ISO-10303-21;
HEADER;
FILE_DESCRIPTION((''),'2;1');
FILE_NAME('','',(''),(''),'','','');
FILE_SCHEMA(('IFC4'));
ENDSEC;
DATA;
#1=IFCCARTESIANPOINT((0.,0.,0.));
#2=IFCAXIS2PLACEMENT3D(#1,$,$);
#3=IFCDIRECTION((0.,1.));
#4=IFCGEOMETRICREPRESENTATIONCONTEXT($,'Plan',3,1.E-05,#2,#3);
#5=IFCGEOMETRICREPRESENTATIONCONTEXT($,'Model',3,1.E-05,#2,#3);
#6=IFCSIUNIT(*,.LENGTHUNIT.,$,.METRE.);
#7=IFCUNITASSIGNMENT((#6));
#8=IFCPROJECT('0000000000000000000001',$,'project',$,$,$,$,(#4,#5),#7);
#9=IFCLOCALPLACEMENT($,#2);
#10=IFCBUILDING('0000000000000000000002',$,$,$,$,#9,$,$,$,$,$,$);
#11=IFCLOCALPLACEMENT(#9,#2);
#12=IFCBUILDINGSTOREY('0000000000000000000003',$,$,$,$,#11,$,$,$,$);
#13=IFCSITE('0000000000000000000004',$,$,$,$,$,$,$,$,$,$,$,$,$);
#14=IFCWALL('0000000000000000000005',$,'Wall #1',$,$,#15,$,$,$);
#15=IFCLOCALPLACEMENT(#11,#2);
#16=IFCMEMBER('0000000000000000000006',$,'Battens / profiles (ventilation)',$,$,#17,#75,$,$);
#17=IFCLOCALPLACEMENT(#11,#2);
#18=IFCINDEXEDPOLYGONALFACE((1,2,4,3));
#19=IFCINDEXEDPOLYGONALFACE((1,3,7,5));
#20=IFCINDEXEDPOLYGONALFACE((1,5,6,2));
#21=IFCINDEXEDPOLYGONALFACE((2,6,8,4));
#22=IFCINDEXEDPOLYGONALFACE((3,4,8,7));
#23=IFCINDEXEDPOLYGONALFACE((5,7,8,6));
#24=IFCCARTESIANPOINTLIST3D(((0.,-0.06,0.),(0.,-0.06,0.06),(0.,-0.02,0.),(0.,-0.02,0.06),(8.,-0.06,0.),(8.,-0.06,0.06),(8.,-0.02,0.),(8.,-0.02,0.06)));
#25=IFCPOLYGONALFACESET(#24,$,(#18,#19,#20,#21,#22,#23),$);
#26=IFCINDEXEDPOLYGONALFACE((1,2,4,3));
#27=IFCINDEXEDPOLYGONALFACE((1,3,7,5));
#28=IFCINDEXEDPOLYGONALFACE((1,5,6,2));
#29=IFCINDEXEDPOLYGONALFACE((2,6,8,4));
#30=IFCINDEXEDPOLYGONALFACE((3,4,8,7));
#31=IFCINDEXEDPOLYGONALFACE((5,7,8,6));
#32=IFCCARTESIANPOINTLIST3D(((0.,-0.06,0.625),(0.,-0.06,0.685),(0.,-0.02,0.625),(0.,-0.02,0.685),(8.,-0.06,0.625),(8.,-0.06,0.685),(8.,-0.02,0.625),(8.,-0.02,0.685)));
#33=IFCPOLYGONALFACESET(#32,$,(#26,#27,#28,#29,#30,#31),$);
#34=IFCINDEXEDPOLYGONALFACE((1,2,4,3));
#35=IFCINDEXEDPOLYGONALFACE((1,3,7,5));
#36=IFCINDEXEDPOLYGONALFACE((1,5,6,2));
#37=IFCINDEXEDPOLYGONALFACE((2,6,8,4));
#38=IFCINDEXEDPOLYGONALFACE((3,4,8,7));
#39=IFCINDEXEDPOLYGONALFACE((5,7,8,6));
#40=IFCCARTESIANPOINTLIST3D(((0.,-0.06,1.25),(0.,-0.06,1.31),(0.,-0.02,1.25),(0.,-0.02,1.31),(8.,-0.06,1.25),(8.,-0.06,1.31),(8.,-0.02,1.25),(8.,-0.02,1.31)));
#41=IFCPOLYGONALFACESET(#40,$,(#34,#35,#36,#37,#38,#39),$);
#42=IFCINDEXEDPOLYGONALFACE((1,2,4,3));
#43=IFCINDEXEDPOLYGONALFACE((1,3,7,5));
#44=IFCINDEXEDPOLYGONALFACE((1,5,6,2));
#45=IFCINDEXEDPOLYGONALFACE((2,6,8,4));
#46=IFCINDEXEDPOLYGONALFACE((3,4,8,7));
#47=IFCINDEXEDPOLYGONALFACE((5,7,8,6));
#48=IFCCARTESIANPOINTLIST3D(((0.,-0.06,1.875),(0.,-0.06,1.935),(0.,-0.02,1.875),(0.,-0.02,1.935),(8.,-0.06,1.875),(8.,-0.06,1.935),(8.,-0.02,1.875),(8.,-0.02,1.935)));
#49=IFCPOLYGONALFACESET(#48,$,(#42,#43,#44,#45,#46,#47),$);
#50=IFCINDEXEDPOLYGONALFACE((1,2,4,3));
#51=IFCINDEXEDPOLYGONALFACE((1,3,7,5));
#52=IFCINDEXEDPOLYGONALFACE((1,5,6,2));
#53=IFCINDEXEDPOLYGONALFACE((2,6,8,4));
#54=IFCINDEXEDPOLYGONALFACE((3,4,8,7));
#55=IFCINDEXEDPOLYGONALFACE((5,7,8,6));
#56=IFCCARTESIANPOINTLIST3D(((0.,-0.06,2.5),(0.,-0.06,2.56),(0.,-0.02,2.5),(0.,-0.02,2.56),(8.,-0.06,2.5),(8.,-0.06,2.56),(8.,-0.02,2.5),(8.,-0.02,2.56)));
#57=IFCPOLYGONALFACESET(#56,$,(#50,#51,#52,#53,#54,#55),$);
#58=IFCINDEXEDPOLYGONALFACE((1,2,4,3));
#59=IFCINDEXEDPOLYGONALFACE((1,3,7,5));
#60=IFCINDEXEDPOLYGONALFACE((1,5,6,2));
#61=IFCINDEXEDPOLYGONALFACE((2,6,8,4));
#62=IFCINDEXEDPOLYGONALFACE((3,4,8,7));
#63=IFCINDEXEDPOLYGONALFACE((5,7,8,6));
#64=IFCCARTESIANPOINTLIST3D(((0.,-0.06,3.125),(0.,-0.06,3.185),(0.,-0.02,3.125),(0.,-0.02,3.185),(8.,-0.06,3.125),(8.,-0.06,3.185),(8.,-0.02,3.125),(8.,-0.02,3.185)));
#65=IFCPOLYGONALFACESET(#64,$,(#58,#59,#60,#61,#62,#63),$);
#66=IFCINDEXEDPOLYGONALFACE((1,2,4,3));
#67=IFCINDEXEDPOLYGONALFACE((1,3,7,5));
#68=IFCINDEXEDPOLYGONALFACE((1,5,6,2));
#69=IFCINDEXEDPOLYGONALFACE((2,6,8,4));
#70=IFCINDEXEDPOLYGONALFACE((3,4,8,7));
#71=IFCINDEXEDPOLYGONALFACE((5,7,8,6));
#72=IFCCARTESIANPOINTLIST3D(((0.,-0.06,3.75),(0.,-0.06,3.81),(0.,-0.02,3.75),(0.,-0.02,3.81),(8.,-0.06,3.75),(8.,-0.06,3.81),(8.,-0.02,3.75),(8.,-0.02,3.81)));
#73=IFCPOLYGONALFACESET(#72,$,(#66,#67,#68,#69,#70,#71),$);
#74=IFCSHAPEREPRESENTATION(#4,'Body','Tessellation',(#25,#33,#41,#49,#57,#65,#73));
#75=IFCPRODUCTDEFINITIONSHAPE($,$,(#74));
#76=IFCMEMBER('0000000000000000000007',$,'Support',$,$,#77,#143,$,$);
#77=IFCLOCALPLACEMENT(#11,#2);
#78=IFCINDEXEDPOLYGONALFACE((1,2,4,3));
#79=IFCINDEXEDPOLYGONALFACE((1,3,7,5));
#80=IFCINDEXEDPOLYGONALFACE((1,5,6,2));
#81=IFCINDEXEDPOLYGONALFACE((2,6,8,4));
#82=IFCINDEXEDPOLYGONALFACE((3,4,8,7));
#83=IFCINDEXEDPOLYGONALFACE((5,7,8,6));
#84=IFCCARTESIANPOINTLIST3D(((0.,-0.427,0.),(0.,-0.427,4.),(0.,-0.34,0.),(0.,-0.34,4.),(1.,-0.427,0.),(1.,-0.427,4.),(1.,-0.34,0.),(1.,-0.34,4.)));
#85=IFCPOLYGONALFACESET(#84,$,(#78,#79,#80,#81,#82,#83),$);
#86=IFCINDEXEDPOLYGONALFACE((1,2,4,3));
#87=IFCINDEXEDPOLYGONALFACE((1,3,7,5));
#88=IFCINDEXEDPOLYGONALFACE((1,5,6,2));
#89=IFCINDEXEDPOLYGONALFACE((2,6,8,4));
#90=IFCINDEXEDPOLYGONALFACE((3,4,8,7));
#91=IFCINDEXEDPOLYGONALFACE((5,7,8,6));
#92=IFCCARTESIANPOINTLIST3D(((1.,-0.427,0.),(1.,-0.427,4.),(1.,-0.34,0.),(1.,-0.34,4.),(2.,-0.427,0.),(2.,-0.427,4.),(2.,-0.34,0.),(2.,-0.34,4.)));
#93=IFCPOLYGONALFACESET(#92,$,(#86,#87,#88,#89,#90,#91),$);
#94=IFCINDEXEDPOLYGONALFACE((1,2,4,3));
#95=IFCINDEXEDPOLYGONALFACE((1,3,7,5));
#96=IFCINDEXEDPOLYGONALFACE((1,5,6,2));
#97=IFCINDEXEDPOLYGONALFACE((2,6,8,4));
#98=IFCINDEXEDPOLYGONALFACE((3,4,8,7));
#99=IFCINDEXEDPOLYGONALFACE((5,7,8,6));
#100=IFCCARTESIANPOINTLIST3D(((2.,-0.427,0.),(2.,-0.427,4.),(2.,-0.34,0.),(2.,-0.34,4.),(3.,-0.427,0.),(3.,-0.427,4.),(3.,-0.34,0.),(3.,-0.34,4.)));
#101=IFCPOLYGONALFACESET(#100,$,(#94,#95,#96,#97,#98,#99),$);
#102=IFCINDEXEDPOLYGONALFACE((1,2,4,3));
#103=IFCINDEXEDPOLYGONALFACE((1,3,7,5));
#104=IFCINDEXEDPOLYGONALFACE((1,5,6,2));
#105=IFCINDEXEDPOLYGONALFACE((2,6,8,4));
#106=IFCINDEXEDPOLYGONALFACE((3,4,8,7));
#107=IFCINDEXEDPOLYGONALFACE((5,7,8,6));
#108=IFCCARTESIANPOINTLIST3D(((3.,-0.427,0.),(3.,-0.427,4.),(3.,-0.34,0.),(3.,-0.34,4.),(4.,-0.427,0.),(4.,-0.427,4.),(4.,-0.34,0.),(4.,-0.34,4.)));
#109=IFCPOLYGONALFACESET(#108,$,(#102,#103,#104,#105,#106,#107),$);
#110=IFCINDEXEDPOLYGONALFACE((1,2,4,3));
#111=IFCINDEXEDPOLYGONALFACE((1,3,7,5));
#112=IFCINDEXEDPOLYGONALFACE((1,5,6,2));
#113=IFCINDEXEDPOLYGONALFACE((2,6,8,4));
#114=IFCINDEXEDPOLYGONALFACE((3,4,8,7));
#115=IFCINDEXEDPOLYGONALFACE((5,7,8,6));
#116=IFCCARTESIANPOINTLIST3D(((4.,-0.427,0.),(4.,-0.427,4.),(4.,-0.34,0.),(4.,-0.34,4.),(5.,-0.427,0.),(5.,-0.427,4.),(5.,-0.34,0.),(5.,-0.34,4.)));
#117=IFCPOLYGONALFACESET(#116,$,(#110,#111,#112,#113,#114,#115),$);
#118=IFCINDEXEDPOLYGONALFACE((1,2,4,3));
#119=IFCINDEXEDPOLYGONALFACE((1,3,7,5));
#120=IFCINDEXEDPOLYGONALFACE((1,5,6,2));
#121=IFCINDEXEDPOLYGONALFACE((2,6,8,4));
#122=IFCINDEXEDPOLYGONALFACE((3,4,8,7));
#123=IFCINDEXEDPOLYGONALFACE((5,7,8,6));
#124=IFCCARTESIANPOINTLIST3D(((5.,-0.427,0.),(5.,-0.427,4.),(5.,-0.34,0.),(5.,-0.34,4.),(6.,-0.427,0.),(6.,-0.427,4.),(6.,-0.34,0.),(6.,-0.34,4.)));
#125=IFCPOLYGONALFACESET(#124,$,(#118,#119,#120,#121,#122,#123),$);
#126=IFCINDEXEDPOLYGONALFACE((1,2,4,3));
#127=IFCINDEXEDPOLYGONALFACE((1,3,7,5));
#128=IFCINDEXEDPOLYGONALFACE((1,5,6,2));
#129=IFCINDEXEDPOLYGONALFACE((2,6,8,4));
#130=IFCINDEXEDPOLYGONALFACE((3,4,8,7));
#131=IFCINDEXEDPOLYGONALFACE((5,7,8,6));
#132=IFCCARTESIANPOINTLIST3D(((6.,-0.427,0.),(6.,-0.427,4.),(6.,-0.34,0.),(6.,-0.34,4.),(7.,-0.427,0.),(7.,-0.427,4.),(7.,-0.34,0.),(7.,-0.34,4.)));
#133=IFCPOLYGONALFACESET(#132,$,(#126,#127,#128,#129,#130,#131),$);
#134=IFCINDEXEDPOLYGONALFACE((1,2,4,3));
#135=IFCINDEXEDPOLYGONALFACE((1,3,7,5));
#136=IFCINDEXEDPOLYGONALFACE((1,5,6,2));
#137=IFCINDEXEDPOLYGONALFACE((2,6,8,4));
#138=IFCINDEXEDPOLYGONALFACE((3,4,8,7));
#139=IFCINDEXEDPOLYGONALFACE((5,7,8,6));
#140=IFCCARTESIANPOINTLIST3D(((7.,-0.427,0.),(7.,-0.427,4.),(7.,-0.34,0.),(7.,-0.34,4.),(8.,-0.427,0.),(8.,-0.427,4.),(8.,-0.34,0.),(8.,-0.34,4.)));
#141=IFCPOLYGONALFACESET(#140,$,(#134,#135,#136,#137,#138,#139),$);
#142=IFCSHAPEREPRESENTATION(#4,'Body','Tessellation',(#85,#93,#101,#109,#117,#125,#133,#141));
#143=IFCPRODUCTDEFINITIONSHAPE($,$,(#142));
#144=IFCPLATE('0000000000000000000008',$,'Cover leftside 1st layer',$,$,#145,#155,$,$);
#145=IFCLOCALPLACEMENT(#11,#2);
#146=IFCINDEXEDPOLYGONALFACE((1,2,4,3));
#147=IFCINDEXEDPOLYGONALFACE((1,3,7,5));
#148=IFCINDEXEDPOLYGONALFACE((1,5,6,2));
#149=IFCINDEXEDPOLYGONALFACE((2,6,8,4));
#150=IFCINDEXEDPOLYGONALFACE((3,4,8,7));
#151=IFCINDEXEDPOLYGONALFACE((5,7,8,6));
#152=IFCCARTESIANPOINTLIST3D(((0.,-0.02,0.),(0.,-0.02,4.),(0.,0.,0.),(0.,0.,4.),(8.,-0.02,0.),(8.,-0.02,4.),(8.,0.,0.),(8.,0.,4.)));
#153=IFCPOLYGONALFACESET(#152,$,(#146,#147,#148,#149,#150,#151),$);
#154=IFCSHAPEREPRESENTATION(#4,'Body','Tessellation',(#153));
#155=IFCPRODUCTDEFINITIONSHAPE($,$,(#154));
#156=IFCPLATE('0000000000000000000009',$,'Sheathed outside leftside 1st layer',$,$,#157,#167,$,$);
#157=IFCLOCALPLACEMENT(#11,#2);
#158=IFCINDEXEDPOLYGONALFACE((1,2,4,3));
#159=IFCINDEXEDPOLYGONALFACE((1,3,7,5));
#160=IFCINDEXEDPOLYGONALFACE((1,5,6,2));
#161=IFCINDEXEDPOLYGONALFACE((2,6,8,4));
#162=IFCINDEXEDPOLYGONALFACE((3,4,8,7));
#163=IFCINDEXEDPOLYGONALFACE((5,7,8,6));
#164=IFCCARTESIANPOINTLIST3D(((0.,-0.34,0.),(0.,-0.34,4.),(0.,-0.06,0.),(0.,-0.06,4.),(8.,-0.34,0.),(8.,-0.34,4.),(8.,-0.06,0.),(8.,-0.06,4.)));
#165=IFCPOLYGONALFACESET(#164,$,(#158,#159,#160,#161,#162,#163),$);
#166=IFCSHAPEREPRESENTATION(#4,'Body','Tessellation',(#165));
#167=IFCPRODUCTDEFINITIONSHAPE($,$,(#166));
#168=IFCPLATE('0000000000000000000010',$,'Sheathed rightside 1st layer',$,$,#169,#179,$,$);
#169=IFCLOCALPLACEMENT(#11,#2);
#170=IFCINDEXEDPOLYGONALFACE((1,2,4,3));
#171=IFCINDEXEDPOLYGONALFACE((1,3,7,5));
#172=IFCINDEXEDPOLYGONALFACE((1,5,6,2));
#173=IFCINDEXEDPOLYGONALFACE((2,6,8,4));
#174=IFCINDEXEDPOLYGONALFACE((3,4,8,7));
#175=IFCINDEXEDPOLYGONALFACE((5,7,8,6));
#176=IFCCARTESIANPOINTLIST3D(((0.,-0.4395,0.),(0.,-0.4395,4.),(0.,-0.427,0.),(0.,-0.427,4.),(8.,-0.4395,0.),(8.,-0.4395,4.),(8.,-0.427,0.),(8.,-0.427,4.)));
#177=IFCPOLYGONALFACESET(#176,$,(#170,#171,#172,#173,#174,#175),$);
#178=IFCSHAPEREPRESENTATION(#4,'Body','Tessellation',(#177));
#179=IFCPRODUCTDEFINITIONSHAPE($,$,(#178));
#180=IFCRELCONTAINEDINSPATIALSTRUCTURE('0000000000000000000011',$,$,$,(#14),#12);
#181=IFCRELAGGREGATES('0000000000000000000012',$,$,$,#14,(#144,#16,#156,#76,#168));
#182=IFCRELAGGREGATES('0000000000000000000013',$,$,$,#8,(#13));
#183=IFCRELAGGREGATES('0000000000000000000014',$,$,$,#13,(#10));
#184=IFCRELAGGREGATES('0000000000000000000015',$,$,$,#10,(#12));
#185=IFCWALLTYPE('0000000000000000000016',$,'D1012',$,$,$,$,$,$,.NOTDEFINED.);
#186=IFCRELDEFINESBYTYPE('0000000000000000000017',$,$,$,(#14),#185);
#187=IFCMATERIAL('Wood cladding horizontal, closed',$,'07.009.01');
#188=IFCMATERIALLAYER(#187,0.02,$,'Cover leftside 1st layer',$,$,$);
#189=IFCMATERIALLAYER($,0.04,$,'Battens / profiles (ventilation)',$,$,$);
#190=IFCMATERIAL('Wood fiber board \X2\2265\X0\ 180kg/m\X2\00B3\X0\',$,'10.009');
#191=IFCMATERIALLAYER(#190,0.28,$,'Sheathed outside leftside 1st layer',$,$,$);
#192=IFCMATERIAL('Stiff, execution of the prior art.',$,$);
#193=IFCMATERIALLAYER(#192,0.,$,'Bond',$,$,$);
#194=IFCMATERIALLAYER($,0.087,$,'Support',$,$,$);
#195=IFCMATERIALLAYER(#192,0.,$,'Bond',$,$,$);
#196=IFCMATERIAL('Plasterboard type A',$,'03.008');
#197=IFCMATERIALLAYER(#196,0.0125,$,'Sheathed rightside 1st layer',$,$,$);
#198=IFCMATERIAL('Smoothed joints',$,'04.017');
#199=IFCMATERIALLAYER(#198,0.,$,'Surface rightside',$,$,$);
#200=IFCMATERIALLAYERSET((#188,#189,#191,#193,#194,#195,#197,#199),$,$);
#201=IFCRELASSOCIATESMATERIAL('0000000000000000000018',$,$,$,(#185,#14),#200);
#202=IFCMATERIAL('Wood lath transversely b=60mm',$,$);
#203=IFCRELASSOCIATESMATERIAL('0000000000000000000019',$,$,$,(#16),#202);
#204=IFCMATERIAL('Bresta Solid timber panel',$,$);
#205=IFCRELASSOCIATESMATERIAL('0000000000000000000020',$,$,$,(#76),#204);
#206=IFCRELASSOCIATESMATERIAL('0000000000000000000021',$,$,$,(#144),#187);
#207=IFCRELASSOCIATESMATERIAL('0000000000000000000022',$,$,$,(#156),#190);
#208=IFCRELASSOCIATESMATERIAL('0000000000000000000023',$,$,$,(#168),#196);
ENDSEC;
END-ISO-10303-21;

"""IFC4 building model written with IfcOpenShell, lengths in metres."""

from ifc_helpers import new_model, si_unit, direction, frame, frame_2d, origin, origin_with_axes, place, context, project, spatial, rectangle, extrude, material, layer, layer_set, type_object, element, aggregate, save


model = new_model("IFC4")

# Units and contexts
plan_context = context("Plan", 3, precision=1e-05, world=origin(), true_north=direction((0.0, 1.0)))
model_context = context("Model", 3, precision=1e-05, world=origin(), true_north=direction((0.0, 1.0)))
ifc_project = project(units=[si_unit("LENGTHUNIT", "METRE")], contexts=[plan_context, model_context])

# Site, building, storey
site = spatial("IfcSite", under=ifc_project)
building_placement = place(None, origin())
building = spatial("IfcBuilding", under=site, at=building_placement)
storey_placement = place(building_placement, origin())
storey = spatial("IfcBuildingStorey", under=building, at=storey_placement)

# Wall, members, plates
ifc_material_1 = material(Name="Wood cladding horizontal, closed", Category="07.009.01")
ifc_layer_1 = layer(ifc_material_1, 0.02, Name="Cover leftside 1st layer")
ifc_layer_2 = layer(None, 0.04, Name="Battens / profiles (ventilation)")
ifc_material_2 = material(Name="Wood fiber board ≥ 180kg/m³", Category="10.009")
ifc_layer_3 = layer(ifc_material_2, 0.28, Name="Sheathed outside leftside 1st layer")
ifc_material_3 = material(Name="Stiff, execution of the prior art.")
ifc_layer_4 = layer(ifc_material_3, 0.0, Name="Bond")
ifc_layer_5 = layer(None, 0.087, Name="Support")
ifc_layer_6 = layer(ifc_material_3, 0.0, Name="Bond")
ifc_material_4 = material(Name="Plasterboard type A", Category="03.008")
ifc_layer_7 = layer(ifc_material_4, 0.0125, Name="Sheathed rightside 1st layer")
ifc_material_5 = material(Name="Smoothed joints", Category="04.017")
ifc_layer_8 = layer(ifc_material_5, 0.0, Name="Surface rightside")
ifc_layer_set = layer_set([ifc_layer_1, ifc_layer_2, ifc_layer_3, ifc_layer_4, ifc_layer_5, ifc_layer_6, ifc_layer_7, ifc_layer_8])
wall_type = type_object("IfcWallType", Name="D1012", PredefinedType="NOTDEFINED", material=ifc_layer_set)
wall_placement = place(None, frame((0.0, 0.0, 0.0), z_axis=(0.0, -1.0, 0.0), x_axis=(1.0, 0.0, 0.0)))
wall = element("IfcWall", 1, at=wall_placement, inside=storey, type_object=wall_type, material=ifc_layer_set, Name="Wall #1")
ifc_material_6 = material(Name="Wood lath transversely b=60mm")
member_1_placement = place(wall_placement, origin())
member_1 = element("IfcMember", 2, at=member_1_placement, material=ifc_material_6, Name="Battens / profiles (ventilation)", context=plan_context, shape_type="SweptSolid", body=[
    extrude(rectangle(XDim=0.06, YDim=0.04, at=frame_2d((0.03, 0.02), x_axis=(1.0, 0.0))), frame((0.0, 0.0, 0.02), z_axis=(1.0, 0.0, 0.0), x_axis=(0.0, 1.0, 0.0)), (0.0, 0.0, 1.0), 8.0),
    extrude(rectangle(XDim=0.06, YDim=0.04, at=frame_2d((0.03, 0.02), x_axis=(1.0, 0.0))), frame((0.0, 0.625, 0.02), z_axis=(1.0, 0.0, 0.0), x_axis=(0.0, 1.0, 0.0)), (0.0, 0.0, 1.0), 8.0),
    extrude(rectangle(XDim=0.06, YDim=0.04, at=frame_2d((0.03, 0.02), x_axis=(1.0, 0.0))), frame((0.0, 1.25, 0.02), z_axis=(1.0, 0.0, 0.0), x_axis=(0.0, 1.0, 0.0)), (0.0, 0.0, 1.0), 8.0),
    extrude(rectangle(XDim=0.06, YDim=0.04, at=frame_2d((0.03, 0.02), x_axis=(1.0, 0.0))), frame((0.0, 1.875, 0.02), z_axis=(1.0, 0.0, 0.0), x_axis=(0.0, 1.0, 0.0)), (0.0, 0.0, 1.0), 8.0),
    extrude(rectangle(XDim=0.06, YDim=0.04, at=frame_2d((0.03, 0.02), x_axis=(1.0, 0.0))), frame((0.0, 2.5, 0.02), z_axis=(1.0, 0.0, 0.0), x_axis=(0.0, 1.0, 0.0)), (0.0, 0.0, 1.0), 8.0),
    extrude(rectangle(XDim=0.06, YDim=0.04, at=frame_2d((0.03, 0.02), x_axis=(1.0, 0.0))), frame((0.0, 3.125, 0.02), z_axis=(1.0, 0.0, 0.0), x_axis=(0.0, 1.0, 0.0)), (0.0, 0.0, 1.0), 8.0),
    extrude(rectangle(XDim=0.06, YDim=0.04, at=frame_2d((0.03, 0.02), x_axis=(1.0, 0.0))), frame((0.0, 3.75, 0.02), z_axis=(1.0, 0.0, 0.0), x_axis=(0.0, 1.0, 0.0)), (0.0, 0.0, 1.0), 8.0),
])
ifc_material_7 = material(Name="Bresta Solid timber panel")
member_2_placement = place(wall_placement, origin())
member_2 = element("IfcMember", 3, at=member_2_placement, material=ifc_material_7, Name="Support", context=plan_context, shape_type="SweptSolid", body=[
    extrude(rectangle(XDim=1.0, YDim=0.087, at=frame_2d((0.5, 0.0435), x_axis=(1.0, 0.0))), frame((0.0, 4.0, 0.34), z_axis=(0.0, -1.0, 0.0), x_axis=(1.0, 0.0, 0.0)), (0.0, 0.0, 1.0), 4.0),
    extrude(rectangle(XDim=1.0, YDim=0.087, at=frame_2d((0.5, 0.0435), x_axis=(1.0, 0.0))), frame((1.0, 4.0, 0.34), z_axis=(0.0, -1.0, 0.0), x_axis=(1.0, 0.0, 0.0)), (0.0, 0.0, 1.0), 4.0),
    extrude(rectangle(XDim=1.0, YDim=0.087, at=frame_2d((0.5, 0.0435), x_axis=(1.0, 0.0))), frame((2.0, 4.0, 0.34), z_axis=(0.0, -1.0, 0.0), x_axis=(1.0, 0.0, 0.0)), (0.0, 0.0, 1.0), 4.0),
    extrude(rectangle(XDim=1.0, YDim=0.087, at=frame_2d((0.5, 0.0435), x_axis=(1.0, 0.0))), frame((3.0, 4.0, 0.34), z_axis=(0.0, -1.0, 0.0), x_axis=(1.0, 0.0, 0.0)), (0.0, 0.0, 1.0), 4.0),
    extrude(rectangle(XDim=1.0, YDim=0.087, at=frame_2d((0.5, 0.0435), x_axis=(1.0, 0.0))), frame((4.0, 4.0, 0.34), z_axis=(0.0, -1.0, 0.0), x_axis=(1.0, 0.0, 0.0)), (0.0, 0.0, 1.0), 4.0),
    extrude(rectangle(XDim=1.0, YDim=0.087, at=frame_2d((0.5, 0.0435), x_axis=(1.0, 0.0))), frame((5.0, 4.0, 0.34), z_axis=(0.0, -1.0, 0.0), x_axis=(1.0, 0.0, 0.0)), (0.0, 0.0, 1.0), 4.0),
    extrude(rectangle(XDim=1.0, YDim=0.087, at=frame_2d((0.5, 0.0435), x_axis=(1.0, 0.0))), frame((6.0, 4.0, 0.34), z_axis=(0.0, -1.0, 0.0), x_axis=(1.0, 0.0, 0.0)), (0.0, 0.0, 1.0), 4.0),
    extrude(rectangle(XDim=1.0, YDim=0.087, at=frame_2d((0.5, 0.0435), x_axis=(1.0, 0.0))), frame((7.0, 4.0, 0.34), z_axis=(0.0, -1.0, 0.0), x_axis=(1.0, 0.0, 0.0)), (0.0, 0.0, 1.0), 4.0),
])
plate_1_placement = place(wall_placement, origin())
plate_1 = element("IfcPlate", 4, at=plate_1_placement, material=ifc_material_1, Name="Cover leftside 1st layer", context=plan_context, shape_type="SweptSolid", body=[
    extrude(rectangle(XDim=8.0, YDim=4.0, at=frame_2d((4.0, 2.0), x_axis=(1.0, 0.0))), origin_with_axes(), (0.0, 0.0, 1.0), 0.02),
])
plate_2_placement = place(wall_placement, origin())
plate_2 = element("IfcPlate", 5, at=plate_2_placement, material=ifc_material_2, Name="Sheathed outside leftside 1st layer", context=plan_context, shape_type="SweptSolid", body=[
    extrude(rectangle(XDim=8.0, YDim=4.0, at=frame_2d((4.0, 2.0), x_axis=(1.0, 0.0))), frame((0.0, 0.0, 0.06), z_axis=(0.0, 0.0, 1.0), x_axis=(1.0, 0.0, 0.0)), (0.0, 0.0, 1.0), 0.28),
])
plate_3_placement = place(wall_placement, origin())
plate_3 = element("IfcPlate", 6, at=plate_3_placement, material=ifc_material_4, Name="Sheathed rightside 1st layer", context=plan_context, shape_type="SweptSolid", body=[
    extrude(rectangle(XDim=8.0, YDim=4.0, at=frame_2d((4.0, 2.0), x_axis=(1.0, 0.0))), frame((0.0, 0.0, 0.427), z_axis=(0.0, 0.0, 1.0), x_axis=(1.0, 0.0, 0.0)), (0.0, 0.0, 1.0), 0.0125),
])
aggregate(wall, [plate_1, member_1, plate_2, member_2, plate_3])

save(model, "model.ifc")
